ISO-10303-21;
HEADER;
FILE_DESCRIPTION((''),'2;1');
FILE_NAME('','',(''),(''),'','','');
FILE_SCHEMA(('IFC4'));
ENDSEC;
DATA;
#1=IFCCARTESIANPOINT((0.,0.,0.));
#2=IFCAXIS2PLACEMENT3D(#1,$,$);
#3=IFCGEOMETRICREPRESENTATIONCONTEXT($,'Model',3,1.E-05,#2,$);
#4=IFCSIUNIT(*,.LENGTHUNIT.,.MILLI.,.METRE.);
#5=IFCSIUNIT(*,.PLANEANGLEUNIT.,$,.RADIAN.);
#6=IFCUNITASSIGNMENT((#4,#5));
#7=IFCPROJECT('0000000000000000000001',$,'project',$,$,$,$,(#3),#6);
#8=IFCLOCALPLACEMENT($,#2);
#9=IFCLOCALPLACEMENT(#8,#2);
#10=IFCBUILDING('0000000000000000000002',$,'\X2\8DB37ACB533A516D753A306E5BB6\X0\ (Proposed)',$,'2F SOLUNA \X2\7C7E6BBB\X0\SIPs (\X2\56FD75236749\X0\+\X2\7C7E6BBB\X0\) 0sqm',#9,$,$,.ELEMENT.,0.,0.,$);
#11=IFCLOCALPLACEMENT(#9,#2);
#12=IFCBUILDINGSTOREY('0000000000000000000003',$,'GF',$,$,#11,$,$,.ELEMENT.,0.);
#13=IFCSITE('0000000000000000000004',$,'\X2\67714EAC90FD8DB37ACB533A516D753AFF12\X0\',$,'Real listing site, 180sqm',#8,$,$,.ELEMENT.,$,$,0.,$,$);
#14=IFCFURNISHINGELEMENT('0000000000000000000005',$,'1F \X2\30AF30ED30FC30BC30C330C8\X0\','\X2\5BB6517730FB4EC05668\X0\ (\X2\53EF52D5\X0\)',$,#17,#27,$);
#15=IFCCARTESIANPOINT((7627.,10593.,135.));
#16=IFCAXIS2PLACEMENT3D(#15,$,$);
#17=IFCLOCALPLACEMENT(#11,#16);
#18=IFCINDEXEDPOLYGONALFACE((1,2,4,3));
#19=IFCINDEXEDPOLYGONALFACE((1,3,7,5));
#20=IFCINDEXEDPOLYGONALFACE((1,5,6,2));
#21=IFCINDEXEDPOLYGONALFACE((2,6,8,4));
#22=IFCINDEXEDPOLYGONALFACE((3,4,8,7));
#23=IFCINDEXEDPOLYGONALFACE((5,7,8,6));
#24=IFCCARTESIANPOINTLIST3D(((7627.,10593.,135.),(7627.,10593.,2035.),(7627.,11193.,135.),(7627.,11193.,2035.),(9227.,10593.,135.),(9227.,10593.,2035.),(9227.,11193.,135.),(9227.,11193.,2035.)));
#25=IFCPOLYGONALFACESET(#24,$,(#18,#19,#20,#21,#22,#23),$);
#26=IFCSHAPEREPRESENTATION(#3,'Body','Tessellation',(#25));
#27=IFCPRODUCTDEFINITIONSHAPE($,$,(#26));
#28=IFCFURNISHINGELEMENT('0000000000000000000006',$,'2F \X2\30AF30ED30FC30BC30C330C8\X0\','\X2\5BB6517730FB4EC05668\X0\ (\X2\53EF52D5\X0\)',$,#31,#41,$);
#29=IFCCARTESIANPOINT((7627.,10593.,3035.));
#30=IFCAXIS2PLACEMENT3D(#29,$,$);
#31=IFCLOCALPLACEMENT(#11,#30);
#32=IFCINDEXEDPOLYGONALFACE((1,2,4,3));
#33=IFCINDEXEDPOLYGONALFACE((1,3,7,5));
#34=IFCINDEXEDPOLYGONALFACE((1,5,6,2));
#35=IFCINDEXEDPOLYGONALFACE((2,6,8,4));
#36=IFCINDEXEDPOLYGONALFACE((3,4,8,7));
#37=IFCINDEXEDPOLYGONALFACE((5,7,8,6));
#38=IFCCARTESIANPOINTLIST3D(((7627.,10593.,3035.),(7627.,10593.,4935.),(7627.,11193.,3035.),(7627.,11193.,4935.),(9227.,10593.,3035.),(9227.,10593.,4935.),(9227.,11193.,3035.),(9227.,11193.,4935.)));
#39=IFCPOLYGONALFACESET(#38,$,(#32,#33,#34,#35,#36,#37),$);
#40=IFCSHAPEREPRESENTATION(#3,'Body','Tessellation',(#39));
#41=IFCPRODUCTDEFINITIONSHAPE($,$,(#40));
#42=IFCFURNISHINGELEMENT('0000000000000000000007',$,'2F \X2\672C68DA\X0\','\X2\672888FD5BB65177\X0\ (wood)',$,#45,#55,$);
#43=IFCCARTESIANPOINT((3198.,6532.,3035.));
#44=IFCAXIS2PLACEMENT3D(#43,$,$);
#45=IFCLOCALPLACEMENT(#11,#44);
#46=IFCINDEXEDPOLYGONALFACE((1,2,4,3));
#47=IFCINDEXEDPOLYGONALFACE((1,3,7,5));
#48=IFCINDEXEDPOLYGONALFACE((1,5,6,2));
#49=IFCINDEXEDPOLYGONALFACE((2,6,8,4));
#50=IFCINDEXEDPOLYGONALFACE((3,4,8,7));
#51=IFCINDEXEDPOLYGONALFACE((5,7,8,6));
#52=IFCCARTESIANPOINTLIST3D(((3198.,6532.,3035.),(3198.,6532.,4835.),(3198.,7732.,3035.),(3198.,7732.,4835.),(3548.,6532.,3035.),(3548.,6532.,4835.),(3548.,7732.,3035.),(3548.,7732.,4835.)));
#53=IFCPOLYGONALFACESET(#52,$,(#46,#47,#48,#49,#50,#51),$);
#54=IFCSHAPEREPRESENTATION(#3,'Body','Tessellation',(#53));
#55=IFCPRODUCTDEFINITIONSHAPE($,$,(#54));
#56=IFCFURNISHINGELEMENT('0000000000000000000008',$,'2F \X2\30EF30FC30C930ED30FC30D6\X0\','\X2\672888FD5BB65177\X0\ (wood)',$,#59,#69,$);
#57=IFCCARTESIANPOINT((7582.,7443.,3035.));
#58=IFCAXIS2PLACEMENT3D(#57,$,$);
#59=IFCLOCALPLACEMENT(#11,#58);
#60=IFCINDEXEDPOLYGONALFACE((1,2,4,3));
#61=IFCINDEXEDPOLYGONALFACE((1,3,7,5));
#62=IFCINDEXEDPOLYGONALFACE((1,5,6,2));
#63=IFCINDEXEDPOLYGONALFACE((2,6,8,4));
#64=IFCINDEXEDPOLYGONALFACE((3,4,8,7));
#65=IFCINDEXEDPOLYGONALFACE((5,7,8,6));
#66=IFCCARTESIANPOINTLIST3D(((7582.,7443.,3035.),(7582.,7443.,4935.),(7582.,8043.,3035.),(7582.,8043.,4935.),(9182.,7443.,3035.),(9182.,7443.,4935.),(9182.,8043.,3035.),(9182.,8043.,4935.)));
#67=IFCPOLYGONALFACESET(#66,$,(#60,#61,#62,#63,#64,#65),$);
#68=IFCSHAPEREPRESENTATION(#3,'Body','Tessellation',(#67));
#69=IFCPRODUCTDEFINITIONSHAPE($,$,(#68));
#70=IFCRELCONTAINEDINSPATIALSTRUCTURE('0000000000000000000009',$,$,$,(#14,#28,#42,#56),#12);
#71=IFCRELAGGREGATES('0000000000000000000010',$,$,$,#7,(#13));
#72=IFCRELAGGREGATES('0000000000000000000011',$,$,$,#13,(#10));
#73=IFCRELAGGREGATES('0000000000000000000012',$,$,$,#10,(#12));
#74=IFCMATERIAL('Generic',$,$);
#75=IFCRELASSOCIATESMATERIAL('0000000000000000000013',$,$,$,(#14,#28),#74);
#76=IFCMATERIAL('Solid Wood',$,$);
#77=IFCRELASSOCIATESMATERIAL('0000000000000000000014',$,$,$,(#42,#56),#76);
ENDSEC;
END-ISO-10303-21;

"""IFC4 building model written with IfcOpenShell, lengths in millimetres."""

from ifc_helpers import new_model, si_unit, frame, frame_2d, origin, place, context, project, spatial, rectangle, extrude, material, element, save


model = new_model("IFC4")

# Units and contexts
model_context = context("Model", 3, precision=1e-05, world=origin())
ifc_project = project(units=[si_unit("LENGTHUNIT", "METRE", prefix="MILLI"), si_unit("PLANEANGLEUNIT", "RADIAN")], contexts=[model_context])

# Site, building, storey
site_placement = place(None, origin())
site = spatial("IfcSite", under=ifc_project, at=site_placement, Name="東京都足立区六町２", ObjectType="Real listing site, 180sqm", CompositionType="ELEMENT", RefElevation=0.0)
building_placement = place(site_placement, origin())
building = spatial("IfcBuilding", under=site, at=building_placement, Name="足立区六町の家 (Proposed)", ObjectType="2F SOLUNA 籾殻SIPs (国産杉+籾殻) 0sqm", CompositionType="ELEMENT", ElevationOfRefHeight=0.0, ElevationOfTerrain=0.0)
storey_placement = place(building_placement, origin())
storey = spatial("IfcBuildingStorey", under=building, at=storey_placement, Name="GF", CompositionType="ELEMENT", Elevation=0.0)

# Shared definitions
ifc_material_1 = material(Name="Solid Wood")

# Shared definitions
ifc_material_2 = material(Name="Generic")

# Furnishing elements
furnishing_1_placement = place(storey_placement, frame((7627.0, 10593.0, 135.0)))
element("IfcFurnishingElement", 1, at=furnishing_1_placement, inside=storey, material=ifc_material_2, Name="1F クローゼット", Description="家具・什器 (可動)", context=model_context, shape_type="SweptSolid", body=[
    extrude(rectangle(XDim=1600.0, YDim=600.0, at=frame_2d((800.0, 300.0))), frame((7627.0, 10593.0, 135.0)), (0.0, 0.0, 1.0), 1900.0),
])
furnishing_2_placement = place(storey_placement, frame((7627.0, 10593.0, 3035.0)))
element("IfcFurnishingElement", 2, at=furnishing_2_placement, inside=storey, material=ifc_material_2, Name="2F クローゼット", Description="家具・什器 (可動)", context=model_context, shape_type="SweptSolid", body=[
    extrude(rectangle(XDim=1600.0, YDim=600.0, at=frame_2d((800.0, 300.0))), frame((7627.0, 10593.0, 3035.0)), (0.0, 0.0, 1.0), 1900.0),
])
furnishing_3_placement = place(storey_placement, frame((3198.0, 6532.0, 3035.0)))
element("IfcFurnishingElement", 3, at=furnishing_3_placement, inside=storey, material=ifc_material_1, Name="2F 本棚", Description="木製家具 (wood)", context=model_context, shape_type="SweptSolid", body=[
    extrude(rectangle(XDim=350.0, YDim=1200.0, at=frame_2d((175.0, 600.0))), frame((3198.0, 6532.0, 3035.0)), (0.0, 0.0, 1.0), 1800.0),
])
furnishing_4_placement = place(storey_placement, frame((7582.0, 7443.0, 3035.0)))
element("IfcFurnishingElement", 4, at=furnishing_4_placement, inside=storey, material=ifc_material_1, Name="2F ワードローブ", Description="木製家具 (wood)", context=model_context, shape_type="SweptSolid", body=[
    extrude(rectangle(XDim=1600.0, YDim=600.0, at=frame_2d((800.0, 300.0))), frame((7582.0, 7443.0, 3035.0)), (0.0, 0.0, 1.0), 1900.0),
])

save(model, "model.ifc")
